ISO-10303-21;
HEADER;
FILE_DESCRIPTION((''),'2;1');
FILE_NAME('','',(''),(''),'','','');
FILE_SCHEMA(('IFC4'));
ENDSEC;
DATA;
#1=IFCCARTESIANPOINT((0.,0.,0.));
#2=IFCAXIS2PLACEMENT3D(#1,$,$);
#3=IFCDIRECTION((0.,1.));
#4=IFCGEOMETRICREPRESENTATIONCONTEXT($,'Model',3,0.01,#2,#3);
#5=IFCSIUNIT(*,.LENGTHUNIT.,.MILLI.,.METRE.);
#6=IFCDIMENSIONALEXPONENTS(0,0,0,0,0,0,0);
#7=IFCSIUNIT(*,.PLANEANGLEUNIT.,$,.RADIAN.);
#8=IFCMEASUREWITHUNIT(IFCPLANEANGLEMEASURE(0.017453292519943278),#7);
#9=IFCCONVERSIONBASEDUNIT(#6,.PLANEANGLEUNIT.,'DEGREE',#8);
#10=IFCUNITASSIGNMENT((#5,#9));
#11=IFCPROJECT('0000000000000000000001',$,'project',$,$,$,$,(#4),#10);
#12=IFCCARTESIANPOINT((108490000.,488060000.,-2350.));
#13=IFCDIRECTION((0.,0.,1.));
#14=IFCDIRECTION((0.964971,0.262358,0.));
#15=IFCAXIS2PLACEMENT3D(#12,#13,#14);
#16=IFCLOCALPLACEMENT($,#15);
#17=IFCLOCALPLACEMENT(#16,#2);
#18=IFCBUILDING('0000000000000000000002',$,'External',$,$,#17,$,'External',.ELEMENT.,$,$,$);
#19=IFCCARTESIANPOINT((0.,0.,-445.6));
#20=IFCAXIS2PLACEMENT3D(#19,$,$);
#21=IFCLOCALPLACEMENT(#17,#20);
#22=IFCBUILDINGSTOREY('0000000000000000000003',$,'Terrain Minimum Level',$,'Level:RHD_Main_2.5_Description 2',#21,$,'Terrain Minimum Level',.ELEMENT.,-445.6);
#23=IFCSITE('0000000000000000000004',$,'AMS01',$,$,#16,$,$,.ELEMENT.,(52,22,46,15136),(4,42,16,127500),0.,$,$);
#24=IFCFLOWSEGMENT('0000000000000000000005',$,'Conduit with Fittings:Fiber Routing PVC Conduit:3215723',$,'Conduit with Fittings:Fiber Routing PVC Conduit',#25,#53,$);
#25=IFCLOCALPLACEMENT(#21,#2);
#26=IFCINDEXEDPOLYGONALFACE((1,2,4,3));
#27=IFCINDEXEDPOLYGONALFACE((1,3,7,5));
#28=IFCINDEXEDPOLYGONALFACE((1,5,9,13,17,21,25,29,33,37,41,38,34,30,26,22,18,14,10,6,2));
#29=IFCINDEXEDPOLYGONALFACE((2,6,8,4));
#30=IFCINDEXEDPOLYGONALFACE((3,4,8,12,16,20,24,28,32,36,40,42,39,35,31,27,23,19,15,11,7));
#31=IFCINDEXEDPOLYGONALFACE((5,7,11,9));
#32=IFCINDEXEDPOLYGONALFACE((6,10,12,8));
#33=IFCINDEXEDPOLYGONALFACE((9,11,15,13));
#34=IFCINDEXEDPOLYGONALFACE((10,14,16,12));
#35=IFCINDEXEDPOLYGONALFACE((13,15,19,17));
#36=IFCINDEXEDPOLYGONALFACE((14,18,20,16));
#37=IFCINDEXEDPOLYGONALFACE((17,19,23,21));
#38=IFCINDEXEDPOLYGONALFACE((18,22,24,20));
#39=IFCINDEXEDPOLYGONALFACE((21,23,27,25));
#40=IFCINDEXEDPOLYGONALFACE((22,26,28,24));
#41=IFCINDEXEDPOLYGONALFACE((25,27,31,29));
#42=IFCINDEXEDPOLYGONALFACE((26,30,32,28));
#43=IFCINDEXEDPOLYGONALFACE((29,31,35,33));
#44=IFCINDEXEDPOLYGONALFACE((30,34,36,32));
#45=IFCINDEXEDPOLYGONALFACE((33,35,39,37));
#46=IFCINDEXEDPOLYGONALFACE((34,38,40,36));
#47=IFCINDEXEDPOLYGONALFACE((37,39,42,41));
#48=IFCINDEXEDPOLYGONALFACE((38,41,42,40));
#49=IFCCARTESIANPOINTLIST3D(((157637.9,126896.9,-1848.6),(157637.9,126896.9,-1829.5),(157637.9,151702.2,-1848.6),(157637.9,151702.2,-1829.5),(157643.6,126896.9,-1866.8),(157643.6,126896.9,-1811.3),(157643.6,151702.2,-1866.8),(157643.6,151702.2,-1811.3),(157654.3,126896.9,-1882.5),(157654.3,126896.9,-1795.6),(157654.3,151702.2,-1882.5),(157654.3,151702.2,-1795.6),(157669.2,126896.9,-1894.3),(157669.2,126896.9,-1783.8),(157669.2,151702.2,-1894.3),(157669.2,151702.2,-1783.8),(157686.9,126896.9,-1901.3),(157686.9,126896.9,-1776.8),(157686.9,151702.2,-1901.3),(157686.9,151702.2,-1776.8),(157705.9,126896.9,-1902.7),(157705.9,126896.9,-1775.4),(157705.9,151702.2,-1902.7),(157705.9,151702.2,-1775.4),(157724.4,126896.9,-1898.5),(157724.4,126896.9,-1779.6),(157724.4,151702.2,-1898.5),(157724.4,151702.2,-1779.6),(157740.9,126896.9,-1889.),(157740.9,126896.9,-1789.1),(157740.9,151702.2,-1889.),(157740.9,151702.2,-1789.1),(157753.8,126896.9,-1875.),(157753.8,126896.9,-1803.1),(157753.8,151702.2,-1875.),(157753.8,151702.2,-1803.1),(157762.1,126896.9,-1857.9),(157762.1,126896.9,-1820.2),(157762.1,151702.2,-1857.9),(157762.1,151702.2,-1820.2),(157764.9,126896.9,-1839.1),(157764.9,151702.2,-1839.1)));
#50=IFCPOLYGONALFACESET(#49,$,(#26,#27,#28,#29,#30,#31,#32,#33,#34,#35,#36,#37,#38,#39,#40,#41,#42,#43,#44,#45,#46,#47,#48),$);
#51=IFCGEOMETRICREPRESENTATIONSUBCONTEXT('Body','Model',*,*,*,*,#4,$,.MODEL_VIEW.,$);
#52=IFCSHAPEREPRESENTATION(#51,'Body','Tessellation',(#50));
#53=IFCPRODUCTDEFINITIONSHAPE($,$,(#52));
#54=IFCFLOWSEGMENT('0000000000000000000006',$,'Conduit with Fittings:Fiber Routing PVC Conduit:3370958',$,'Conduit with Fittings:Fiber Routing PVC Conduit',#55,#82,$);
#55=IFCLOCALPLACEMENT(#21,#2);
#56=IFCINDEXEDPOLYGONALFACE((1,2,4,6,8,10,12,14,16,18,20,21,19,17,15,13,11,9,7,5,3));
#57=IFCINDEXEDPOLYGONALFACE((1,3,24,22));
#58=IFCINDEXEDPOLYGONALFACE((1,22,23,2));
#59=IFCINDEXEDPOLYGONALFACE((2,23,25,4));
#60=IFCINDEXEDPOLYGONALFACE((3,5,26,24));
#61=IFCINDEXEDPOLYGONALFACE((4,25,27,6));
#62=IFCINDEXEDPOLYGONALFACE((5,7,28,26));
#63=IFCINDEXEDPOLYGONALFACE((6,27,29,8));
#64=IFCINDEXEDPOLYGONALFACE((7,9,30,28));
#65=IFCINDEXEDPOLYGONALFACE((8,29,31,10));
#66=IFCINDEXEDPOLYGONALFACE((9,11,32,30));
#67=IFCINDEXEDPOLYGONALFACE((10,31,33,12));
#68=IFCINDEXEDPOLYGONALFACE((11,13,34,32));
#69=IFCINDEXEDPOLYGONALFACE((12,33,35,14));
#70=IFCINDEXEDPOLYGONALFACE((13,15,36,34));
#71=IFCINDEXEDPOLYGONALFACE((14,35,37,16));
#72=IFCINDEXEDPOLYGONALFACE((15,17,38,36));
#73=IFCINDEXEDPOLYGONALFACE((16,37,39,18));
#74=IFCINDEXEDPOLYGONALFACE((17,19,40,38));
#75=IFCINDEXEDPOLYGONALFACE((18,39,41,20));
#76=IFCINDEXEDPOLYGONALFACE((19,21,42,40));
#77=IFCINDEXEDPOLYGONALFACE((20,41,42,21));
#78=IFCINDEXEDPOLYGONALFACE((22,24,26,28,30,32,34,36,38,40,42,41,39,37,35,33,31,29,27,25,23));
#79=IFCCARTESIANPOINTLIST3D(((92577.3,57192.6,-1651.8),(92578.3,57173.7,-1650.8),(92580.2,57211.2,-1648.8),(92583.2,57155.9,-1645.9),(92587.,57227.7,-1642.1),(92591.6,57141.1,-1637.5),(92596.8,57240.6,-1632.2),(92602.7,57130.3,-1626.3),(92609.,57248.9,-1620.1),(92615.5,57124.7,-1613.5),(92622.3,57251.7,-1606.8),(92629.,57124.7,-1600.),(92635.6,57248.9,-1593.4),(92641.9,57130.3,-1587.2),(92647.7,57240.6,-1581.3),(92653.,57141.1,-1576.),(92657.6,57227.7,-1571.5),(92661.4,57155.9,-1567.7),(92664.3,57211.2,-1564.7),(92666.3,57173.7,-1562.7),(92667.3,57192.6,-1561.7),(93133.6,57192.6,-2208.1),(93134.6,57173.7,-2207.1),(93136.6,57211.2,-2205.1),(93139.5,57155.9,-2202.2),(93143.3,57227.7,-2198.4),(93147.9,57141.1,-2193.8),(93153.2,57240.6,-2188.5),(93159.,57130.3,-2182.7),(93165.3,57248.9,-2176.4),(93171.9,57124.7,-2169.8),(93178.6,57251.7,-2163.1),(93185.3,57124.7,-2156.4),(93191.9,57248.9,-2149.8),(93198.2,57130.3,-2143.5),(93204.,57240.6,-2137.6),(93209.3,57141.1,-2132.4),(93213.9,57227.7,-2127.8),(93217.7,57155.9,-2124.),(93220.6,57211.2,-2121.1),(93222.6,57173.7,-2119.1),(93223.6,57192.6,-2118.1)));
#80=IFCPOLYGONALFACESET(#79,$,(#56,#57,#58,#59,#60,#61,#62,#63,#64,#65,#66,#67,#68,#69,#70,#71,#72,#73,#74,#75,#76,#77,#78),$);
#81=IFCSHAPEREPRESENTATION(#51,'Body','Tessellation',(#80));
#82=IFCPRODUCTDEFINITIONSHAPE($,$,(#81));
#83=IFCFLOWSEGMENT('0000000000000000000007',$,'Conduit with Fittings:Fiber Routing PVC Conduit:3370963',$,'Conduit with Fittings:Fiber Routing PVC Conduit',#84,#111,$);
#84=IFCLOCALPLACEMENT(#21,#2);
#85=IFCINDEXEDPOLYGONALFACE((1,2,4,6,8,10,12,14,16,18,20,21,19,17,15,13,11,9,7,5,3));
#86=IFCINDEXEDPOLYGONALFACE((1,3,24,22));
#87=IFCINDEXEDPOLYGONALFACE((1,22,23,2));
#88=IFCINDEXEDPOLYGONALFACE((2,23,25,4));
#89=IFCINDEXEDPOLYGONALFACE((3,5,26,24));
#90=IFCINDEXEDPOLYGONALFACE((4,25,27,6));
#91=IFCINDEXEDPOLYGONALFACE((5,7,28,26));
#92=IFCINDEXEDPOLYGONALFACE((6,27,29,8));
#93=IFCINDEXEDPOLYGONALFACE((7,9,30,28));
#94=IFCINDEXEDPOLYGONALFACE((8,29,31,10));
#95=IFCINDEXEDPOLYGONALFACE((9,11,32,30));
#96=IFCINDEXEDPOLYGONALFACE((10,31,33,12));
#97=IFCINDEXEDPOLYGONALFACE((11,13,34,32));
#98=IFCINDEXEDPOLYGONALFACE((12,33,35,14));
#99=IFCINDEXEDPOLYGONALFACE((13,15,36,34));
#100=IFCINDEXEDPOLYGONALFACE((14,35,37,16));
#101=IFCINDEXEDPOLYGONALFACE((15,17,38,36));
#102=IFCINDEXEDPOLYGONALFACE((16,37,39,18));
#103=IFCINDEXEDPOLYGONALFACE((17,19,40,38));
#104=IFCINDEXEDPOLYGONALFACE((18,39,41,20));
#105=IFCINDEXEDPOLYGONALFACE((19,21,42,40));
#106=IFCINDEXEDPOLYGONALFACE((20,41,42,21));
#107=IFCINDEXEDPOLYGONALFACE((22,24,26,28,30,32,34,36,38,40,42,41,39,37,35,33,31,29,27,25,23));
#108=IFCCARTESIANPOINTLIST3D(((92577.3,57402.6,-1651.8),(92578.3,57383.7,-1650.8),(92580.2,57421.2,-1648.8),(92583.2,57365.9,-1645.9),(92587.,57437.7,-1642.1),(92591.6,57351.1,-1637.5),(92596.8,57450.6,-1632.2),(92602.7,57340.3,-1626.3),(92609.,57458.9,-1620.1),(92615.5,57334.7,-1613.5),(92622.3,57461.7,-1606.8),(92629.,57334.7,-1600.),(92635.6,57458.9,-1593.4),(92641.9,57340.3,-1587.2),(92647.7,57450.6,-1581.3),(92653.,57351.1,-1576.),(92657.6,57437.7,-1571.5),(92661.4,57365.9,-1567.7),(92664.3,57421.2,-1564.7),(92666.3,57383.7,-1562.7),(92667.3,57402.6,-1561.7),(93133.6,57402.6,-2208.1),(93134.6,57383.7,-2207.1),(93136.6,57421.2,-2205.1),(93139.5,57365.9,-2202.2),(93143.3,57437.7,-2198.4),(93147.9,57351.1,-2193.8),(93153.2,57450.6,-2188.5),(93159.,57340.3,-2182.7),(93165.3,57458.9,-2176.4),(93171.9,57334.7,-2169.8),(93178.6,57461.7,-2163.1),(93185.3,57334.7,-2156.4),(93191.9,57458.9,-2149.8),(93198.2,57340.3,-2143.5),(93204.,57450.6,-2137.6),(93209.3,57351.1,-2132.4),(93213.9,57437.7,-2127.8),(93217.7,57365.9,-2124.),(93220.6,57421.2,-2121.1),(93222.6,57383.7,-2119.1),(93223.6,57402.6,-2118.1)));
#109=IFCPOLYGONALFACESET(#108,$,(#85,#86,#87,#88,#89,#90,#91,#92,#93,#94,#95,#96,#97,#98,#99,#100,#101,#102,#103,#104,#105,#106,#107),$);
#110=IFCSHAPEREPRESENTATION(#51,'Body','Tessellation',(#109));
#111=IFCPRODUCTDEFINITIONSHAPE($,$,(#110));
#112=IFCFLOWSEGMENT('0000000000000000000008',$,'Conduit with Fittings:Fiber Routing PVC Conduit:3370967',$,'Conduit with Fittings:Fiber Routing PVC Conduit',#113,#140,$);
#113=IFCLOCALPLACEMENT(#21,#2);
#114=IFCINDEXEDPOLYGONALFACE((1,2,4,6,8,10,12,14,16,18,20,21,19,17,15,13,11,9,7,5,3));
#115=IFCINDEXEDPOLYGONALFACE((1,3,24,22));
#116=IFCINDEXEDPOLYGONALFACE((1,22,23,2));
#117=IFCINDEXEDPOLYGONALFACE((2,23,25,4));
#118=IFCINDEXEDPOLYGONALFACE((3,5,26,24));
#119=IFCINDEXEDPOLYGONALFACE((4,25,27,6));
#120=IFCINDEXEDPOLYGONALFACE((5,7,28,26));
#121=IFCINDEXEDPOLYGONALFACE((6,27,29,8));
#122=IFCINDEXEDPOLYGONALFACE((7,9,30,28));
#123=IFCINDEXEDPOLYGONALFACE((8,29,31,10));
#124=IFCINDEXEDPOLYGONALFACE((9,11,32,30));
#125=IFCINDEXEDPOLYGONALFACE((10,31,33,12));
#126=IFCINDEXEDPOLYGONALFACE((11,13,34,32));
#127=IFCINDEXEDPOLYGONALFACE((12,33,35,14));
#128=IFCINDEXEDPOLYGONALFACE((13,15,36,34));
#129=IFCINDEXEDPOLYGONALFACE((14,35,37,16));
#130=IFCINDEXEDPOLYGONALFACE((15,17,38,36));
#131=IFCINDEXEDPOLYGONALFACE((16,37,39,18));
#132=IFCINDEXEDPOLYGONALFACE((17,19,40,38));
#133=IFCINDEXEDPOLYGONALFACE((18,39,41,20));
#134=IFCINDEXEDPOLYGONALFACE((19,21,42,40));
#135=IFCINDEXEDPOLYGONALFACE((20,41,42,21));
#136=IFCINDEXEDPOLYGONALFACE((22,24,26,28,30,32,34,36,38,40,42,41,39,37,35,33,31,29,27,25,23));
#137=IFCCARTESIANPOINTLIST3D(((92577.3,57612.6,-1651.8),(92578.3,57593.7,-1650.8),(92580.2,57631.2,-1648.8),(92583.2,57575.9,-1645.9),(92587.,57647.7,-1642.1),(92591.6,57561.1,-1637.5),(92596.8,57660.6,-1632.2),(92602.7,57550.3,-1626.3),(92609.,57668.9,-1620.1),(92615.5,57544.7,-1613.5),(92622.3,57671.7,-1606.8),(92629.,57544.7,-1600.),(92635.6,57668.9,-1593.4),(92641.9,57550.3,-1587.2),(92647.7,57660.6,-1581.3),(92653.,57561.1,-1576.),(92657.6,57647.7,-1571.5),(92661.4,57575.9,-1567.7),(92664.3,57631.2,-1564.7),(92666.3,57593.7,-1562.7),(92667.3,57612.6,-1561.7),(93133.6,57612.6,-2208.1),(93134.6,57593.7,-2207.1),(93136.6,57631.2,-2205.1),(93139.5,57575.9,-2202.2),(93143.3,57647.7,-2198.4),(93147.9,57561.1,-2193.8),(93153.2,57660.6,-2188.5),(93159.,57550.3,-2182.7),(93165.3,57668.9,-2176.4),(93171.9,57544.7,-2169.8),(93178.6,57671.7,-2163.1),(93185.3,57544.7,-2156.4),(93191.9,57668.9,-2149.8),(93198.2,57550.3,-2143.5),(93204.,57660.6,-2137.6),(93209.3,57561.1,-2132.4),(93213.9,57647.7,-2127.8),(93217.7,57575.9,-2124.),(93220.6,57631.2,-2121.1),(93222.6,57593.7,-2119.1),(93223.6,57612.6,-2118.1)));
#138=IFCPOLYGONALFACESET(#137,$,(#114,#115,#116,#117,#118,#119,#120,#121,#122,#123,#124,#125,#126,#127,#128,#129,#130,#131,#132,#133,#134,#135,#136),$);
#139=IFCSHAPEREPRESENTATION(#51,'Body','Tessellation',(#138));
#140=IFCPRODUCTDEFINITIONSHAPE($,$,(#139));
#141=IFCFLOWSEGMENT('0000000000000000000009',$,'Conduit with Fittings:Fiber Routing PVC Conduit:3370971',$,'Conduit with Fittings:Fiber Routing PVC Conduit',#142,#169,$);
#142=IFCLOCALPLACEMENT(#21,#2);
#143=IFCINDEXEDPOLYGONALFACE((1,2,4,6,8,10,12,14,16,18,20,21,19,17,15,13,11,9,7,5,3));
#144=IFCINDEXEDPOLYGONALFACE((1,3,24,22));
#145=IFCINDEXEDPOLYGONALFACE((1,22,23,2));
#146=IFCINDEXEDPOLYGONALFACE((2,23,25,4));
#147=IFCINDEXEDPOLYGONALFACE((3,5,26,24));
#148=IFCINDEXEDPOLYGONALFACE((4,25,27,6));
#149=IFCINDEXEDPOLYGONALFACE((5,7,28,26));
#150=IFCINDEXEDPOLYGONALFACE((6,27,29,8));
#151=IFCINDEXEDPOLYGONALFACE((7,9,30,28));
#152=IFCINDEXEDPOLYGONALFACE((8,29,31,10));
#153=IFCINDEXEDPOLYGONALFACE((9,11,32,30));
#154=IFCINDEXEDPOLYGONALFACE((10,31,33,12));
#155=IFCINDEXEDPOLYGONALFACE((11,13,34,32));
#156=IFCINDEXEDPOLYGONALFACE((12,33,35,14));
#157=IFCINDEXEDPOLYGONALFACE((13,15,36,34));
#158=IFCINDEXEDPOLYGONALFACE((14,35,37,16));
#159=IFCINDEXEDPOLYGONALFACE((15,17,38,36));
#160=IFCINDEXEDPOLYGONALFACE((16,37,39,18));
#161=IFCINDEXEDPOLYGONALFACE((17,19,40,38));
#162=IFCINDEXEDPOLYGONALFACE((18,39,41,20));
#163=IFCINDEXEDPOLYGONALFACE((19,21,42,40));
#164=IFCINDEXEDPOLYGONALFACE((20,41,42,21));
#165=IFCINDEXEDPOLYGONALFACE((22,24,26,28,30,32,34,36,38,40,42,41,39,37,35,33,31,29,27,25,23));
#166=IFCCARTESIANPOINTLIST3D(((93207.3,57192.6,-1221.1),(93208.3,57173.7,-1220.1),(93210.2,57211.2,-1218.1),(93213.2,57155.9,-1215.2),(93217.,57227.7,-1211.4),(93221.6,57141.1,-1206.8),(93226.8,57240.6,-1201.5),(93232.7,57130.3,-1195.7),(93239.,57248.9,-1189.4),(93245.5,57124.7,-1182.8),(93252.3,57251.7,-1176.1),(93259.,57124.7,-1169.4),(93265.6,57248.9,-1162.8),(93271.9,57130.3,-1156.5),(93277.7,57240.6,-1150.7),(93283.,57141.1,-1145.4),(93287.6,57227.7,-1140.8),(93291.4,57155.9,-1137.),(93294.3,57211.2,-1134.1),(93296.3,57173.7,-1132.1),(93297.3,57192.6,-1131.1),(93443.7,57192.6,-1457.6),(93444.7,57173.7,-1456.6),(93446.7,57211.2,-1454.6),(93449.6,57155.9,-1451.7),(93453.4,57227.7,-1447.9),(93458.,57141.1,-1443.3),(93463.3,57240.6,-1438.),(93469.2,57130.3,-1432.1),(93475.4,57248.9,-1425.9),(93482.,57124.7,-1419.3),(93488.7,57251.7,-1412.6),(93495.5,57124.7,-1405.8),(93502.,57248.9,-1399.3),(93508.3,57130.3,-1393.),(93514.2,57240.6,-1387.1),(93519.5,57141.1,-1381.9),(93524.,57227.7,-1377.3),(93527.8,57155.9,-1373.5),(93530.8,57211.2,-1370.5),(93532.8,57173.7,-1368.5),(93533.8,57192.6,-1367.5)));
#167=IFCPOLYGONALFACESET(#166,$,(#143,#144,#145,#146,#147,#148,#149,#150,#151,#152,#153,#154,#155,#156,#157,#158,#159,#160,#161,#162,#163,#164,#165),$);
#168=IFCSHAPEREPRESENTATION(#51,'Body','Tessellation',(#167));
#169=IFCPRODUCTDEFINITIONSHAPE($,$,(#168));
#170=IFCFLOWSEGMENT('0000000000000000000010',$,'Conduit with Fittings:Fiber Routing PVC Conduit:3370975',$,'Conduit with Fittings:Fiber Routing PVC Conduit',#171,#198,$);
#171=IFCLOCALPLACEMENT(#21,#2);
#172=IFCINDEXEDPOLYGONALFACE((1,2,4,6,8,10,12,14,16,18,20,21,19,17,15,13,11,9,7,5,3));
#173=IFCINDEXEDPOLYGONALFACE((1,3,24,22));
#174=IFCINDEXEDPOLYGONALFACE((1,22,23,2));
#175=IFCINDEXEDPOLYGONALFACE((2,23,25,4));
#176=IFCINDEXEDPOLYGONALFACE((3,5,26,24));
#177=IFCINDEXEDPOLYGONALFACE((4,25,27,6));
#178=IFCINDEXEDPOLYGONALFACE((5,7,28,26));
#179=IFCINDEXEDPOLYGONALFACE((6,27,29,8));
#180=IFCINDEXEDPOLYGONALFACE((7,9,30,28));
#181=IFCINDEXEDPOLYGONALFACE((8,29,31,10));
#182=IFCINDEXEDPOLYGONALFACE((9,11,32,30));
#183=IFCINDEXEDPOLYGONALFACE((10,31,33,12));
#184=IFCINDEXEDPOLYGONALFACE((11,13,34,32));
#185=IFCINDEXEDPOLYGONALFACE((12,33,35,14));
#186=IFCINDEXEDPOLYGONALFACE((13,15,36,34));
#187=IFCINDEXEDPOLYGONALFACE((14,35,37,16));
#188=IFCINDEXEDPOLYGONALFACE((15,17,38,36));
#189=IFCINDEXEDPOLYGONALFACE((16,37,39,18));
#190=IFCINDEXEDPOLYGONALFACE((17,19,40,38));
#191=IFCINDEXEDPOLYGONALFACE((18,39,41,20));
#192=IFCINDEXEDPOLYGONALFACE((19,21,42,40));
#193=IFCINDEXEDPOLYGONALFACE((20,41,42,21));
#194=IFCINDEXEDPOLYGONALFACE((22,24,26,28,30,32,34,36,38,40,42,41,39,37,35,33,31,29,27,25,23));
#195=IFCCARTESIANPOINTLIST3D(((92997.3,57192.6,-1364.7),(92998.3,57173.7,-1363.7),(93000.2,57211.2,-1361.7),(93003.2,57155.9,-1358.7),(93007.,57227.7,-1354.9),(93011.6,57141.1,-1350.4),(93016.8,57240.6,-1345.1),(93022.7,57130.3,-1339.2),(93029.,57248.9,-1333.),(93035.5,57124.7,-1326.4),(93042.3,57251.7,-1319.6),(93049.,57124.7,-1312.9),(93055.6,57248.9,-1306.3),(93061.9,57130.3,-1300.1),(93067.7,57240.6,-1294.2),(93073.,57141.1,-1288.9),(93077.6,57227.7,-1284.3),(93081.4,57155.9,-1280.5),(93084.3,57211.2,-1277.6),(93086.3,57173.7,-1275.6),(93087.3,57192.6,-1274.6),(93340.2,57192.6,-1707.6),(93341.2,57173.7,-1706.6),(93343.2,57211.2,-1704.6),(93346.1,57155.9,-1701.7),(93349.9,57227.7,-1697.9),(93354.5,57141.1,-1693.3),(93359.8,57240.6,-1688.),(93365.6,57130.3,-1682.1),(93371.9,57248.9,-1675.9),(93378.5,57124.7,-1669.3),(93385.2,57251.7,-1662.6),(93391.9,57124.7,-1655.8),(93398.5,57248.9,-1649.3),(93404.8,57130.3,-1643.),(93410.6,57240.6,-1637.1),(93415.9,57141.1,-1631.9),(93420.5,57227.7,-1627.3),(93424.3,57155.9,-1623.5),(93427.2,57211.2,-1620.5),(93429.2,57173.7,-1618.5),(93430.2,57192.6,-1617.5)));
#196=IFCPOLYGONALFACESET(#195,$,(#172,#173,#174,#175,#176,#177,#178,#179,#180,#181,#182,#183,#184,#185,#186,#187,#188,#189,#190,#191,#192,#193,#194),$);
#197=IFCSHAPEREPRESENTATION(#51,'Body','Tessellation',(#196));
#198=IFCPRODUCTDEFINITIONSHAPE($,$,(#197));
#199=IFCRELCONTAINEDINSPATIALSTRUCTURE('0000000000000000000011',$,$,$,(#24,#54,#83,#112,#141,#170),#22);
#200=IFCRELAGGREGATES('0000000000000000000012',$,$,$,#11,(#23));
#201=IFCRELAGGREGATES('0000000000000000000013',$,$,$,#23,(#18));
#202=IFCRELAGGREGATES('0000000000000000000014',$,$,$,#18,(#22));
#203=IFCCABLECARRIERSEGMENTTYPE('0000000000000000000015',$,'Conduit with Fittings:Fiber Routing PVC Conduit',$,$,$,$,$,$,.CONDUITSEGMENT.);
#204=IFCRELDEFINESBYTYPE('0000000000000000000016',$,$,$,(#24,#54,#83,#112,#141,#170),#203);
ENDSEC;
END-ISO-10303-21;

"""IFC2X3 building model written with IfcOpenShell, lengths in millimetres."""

from ifc_helpers import new_model, entity, si_unit, converted_unit, direction, frame, origin, origin_2d_with_axis, place, context, subcontext, project, spatial, circle, extrude, type_object, element, save


model = new_model("IFC2X3")

# Units and contexts
model_context = context("Model", 3, precision=0.01, world=origin(), true_north=direction((0.0, 1.0)))
body_context = subcontext(model_context, "Body", "Model", "MODEL_VIEW")
ifc_project = project(units=[si_unit("LENGTHUNIT", "METRE", prefix="MILLI"), converted_unit("PLANEANGLEUNIT", "DEGREE", entity("IfcPlaneAngleMeasure", 0.017453292519943278), si_unit("PLANEANGLEUNIT", "RADIAN"), dimensions=[0, 0, 0, 0, 0, 0, 0])], contexts=[model_context])

# Site, building, storey
site_placement = place(None, frame((108490000.0, 488060000.0, -2350.0), z_axis=(0.0, 0.0, 1.0), x_axis=(0.964971, 0.262358, 0.0)))
site = spatial("IfcSite", under=ifc_project, at=site_placement, Name="AMS01", CompositionType="ELEMENT", RefLatitude=(52, 22, 46, 15136), RefLongitude=(4, 42, 16, 127500), RefElevation=0.0)
building_placement = place(site_placement, origin())
building = spatial("IfcBuilding", under=site, at=building_placement, Name="External", LongName="External", CompositionType="ELEMENT")
storey_placement = place(building_placement, frame((0.0, 0.0, -445.6)))
storey = spatial("IfcBuildingStorey", under=building, at=storey_placement, Name="Terrain Minimum Level", ObjectType="Level:RHD_Main_2.5_Description 2", LongName="Terrain Minimum Level", CompositionType="ELEMENT", Elevation=-445.6)

# Flow segments
cable_carrier_segment_type = type_object("IfcCableCarrierSegmentType", Name="Conduit with Fittings:Fiber Routing PVC Conduit", PredefinedType="CONDUITSEGMENT")
flow_segment_1_placement = place(storey_placement, origin())
element("IfcFlowSegment", 1, at=flow_segment_1_placement, inside=storey, type_object=cable_carrier_segment_type, Name="Conduit with Fittings:Fiber Routing PVC Conduit:3215723", ObjectType="Conduit with Fittings:Fiber Routing PVC Conduit", context=body_context, shape_type="SweptSolid", body=[
    extrude(circle(Radius=63.9, at=origin_2d_with_axis()), frame((157701.1, 126896.9, -1839.1), z_axis=(0.0, 1.0, 0.0), x_axis=(1.0, 0.0, 0.0)), (0.0, 0.0, 1.0), 24805.3),
])
flow_segment_2_placement = place(storey_placement, origin())
element("IfcFlowSegment", 2, at=flow_segment_2_placement, inside=storey, type_object=cable_carrier_segment_type, Name="Conduit with Fittings:Fiber Routing PVC Conduit:3370958", ObjectType="Conduit with Fittings:Fiber Routing PVC Conduit", context=body_context, shape_type="SweptSolid", body=[
    extrude(circle(Radius=63.9, at=origin_2d_with_axis()), frame((93178.6, 57187.9, -2163.1), z_axis=(-0.707107, 0.0, 0.707107), x_axis=(0.0, 1.0, 0.0)), (0.0, 0.0, 1.0), 786.8),
])
flow_segment_3_placement = place(storey_placement, origin())
element("IfcFlowSegment", 3, at=flow_segment_3_placement, inside=storey, type_object=cable_carrier_segment_type, Name="Conduit with Fittings:Fiber Routing PVC Conduit:3370963", ObjectType="Conduit with Fittings:Fiber Routing PVC Conduit", context=body_context, shape_type="SweptSolid", body=[
    extrude(circle(Radius=63.9, at=origin_2d_with_axis()), frame((92622.3, 57397.9, -1606.8), z_axis=(0.707107, 0.0, -0.707107), x_axis=(0.0, 1.0, 0.0)), (0.0, 0.0, 1.0), 786.8),
])
flow_segment_4_placement = place(storey_placement, origin())
element("IfcFlowSegment", 4, at=flow_segment_4_placement, inside=storey, type_object=cable_carrier_segment_type, Name="Conduit with Fittings:Fiber Routing PVC Conduit:3370967", ObjectType="Conduit with Fittings:Fiber Routing PVC Conduit", context=body_context, shape_type="SweptSolid", body=[
    extrude(circle(Radius=63.9, at=origin_2d_with_axis()), frame((93178.6, 57607.9, -2163.1), z_axis=(-0.707107, 0.0, 0.707107), x_axis=(0.0, 1.0, 0.0)), (0.0, 0.0, 1.0), 786.8),
])
flow_segment_5_placement = place(storey_placement, origin())
element("IfcFlowSegment", 5, at=flow_segment_5_placement, inside=storey, type_object=cable_carrier_segment_type, Name="Conduit with Fittings:Fiber Routing PVC Conduit:3370971", ObjectType="Conduit with Fittings:Fiber Routing PVC Conduit", context=body_context, shape_type="SweptSolid", body=[
    extrude(circle(Radius=63.9, at=origin_2d_with_axis()), frame((93488.7, 57187.9, -1412.6), z_axis=(-0.707107, 0.0, 0.707107), x_axis=(0.0, 1.0, 0.0)), (0.0, 0.0, 1.0), 334.4),
])
flow_segment_6_placement = place(storey_placement, origin())
element("IfcFlowSegment", 6, at=flow_segment_6_placement, inside=storey, type_object=cable_carrier_segment_type, Name="Conduit with Fittings:Fiber Routing PVC Conduit:3370975", ObjectType="Conduit with Fittings:Fiber Routing PVC Conduit", context=body_context, shape_type="SweptSolid", body=[
    extrude(circle(Radius=63.9, at=origin_2d_with_axis()), frame((93042.3, 57187.9, -1319.6), z_axis=(0.707107, 0.0, -0.707107), x_axis=(0.0, 1.0, 0.0)), (0.0, 0.0, 1.0), 485.0),
])

save(model, "model.ifc")
